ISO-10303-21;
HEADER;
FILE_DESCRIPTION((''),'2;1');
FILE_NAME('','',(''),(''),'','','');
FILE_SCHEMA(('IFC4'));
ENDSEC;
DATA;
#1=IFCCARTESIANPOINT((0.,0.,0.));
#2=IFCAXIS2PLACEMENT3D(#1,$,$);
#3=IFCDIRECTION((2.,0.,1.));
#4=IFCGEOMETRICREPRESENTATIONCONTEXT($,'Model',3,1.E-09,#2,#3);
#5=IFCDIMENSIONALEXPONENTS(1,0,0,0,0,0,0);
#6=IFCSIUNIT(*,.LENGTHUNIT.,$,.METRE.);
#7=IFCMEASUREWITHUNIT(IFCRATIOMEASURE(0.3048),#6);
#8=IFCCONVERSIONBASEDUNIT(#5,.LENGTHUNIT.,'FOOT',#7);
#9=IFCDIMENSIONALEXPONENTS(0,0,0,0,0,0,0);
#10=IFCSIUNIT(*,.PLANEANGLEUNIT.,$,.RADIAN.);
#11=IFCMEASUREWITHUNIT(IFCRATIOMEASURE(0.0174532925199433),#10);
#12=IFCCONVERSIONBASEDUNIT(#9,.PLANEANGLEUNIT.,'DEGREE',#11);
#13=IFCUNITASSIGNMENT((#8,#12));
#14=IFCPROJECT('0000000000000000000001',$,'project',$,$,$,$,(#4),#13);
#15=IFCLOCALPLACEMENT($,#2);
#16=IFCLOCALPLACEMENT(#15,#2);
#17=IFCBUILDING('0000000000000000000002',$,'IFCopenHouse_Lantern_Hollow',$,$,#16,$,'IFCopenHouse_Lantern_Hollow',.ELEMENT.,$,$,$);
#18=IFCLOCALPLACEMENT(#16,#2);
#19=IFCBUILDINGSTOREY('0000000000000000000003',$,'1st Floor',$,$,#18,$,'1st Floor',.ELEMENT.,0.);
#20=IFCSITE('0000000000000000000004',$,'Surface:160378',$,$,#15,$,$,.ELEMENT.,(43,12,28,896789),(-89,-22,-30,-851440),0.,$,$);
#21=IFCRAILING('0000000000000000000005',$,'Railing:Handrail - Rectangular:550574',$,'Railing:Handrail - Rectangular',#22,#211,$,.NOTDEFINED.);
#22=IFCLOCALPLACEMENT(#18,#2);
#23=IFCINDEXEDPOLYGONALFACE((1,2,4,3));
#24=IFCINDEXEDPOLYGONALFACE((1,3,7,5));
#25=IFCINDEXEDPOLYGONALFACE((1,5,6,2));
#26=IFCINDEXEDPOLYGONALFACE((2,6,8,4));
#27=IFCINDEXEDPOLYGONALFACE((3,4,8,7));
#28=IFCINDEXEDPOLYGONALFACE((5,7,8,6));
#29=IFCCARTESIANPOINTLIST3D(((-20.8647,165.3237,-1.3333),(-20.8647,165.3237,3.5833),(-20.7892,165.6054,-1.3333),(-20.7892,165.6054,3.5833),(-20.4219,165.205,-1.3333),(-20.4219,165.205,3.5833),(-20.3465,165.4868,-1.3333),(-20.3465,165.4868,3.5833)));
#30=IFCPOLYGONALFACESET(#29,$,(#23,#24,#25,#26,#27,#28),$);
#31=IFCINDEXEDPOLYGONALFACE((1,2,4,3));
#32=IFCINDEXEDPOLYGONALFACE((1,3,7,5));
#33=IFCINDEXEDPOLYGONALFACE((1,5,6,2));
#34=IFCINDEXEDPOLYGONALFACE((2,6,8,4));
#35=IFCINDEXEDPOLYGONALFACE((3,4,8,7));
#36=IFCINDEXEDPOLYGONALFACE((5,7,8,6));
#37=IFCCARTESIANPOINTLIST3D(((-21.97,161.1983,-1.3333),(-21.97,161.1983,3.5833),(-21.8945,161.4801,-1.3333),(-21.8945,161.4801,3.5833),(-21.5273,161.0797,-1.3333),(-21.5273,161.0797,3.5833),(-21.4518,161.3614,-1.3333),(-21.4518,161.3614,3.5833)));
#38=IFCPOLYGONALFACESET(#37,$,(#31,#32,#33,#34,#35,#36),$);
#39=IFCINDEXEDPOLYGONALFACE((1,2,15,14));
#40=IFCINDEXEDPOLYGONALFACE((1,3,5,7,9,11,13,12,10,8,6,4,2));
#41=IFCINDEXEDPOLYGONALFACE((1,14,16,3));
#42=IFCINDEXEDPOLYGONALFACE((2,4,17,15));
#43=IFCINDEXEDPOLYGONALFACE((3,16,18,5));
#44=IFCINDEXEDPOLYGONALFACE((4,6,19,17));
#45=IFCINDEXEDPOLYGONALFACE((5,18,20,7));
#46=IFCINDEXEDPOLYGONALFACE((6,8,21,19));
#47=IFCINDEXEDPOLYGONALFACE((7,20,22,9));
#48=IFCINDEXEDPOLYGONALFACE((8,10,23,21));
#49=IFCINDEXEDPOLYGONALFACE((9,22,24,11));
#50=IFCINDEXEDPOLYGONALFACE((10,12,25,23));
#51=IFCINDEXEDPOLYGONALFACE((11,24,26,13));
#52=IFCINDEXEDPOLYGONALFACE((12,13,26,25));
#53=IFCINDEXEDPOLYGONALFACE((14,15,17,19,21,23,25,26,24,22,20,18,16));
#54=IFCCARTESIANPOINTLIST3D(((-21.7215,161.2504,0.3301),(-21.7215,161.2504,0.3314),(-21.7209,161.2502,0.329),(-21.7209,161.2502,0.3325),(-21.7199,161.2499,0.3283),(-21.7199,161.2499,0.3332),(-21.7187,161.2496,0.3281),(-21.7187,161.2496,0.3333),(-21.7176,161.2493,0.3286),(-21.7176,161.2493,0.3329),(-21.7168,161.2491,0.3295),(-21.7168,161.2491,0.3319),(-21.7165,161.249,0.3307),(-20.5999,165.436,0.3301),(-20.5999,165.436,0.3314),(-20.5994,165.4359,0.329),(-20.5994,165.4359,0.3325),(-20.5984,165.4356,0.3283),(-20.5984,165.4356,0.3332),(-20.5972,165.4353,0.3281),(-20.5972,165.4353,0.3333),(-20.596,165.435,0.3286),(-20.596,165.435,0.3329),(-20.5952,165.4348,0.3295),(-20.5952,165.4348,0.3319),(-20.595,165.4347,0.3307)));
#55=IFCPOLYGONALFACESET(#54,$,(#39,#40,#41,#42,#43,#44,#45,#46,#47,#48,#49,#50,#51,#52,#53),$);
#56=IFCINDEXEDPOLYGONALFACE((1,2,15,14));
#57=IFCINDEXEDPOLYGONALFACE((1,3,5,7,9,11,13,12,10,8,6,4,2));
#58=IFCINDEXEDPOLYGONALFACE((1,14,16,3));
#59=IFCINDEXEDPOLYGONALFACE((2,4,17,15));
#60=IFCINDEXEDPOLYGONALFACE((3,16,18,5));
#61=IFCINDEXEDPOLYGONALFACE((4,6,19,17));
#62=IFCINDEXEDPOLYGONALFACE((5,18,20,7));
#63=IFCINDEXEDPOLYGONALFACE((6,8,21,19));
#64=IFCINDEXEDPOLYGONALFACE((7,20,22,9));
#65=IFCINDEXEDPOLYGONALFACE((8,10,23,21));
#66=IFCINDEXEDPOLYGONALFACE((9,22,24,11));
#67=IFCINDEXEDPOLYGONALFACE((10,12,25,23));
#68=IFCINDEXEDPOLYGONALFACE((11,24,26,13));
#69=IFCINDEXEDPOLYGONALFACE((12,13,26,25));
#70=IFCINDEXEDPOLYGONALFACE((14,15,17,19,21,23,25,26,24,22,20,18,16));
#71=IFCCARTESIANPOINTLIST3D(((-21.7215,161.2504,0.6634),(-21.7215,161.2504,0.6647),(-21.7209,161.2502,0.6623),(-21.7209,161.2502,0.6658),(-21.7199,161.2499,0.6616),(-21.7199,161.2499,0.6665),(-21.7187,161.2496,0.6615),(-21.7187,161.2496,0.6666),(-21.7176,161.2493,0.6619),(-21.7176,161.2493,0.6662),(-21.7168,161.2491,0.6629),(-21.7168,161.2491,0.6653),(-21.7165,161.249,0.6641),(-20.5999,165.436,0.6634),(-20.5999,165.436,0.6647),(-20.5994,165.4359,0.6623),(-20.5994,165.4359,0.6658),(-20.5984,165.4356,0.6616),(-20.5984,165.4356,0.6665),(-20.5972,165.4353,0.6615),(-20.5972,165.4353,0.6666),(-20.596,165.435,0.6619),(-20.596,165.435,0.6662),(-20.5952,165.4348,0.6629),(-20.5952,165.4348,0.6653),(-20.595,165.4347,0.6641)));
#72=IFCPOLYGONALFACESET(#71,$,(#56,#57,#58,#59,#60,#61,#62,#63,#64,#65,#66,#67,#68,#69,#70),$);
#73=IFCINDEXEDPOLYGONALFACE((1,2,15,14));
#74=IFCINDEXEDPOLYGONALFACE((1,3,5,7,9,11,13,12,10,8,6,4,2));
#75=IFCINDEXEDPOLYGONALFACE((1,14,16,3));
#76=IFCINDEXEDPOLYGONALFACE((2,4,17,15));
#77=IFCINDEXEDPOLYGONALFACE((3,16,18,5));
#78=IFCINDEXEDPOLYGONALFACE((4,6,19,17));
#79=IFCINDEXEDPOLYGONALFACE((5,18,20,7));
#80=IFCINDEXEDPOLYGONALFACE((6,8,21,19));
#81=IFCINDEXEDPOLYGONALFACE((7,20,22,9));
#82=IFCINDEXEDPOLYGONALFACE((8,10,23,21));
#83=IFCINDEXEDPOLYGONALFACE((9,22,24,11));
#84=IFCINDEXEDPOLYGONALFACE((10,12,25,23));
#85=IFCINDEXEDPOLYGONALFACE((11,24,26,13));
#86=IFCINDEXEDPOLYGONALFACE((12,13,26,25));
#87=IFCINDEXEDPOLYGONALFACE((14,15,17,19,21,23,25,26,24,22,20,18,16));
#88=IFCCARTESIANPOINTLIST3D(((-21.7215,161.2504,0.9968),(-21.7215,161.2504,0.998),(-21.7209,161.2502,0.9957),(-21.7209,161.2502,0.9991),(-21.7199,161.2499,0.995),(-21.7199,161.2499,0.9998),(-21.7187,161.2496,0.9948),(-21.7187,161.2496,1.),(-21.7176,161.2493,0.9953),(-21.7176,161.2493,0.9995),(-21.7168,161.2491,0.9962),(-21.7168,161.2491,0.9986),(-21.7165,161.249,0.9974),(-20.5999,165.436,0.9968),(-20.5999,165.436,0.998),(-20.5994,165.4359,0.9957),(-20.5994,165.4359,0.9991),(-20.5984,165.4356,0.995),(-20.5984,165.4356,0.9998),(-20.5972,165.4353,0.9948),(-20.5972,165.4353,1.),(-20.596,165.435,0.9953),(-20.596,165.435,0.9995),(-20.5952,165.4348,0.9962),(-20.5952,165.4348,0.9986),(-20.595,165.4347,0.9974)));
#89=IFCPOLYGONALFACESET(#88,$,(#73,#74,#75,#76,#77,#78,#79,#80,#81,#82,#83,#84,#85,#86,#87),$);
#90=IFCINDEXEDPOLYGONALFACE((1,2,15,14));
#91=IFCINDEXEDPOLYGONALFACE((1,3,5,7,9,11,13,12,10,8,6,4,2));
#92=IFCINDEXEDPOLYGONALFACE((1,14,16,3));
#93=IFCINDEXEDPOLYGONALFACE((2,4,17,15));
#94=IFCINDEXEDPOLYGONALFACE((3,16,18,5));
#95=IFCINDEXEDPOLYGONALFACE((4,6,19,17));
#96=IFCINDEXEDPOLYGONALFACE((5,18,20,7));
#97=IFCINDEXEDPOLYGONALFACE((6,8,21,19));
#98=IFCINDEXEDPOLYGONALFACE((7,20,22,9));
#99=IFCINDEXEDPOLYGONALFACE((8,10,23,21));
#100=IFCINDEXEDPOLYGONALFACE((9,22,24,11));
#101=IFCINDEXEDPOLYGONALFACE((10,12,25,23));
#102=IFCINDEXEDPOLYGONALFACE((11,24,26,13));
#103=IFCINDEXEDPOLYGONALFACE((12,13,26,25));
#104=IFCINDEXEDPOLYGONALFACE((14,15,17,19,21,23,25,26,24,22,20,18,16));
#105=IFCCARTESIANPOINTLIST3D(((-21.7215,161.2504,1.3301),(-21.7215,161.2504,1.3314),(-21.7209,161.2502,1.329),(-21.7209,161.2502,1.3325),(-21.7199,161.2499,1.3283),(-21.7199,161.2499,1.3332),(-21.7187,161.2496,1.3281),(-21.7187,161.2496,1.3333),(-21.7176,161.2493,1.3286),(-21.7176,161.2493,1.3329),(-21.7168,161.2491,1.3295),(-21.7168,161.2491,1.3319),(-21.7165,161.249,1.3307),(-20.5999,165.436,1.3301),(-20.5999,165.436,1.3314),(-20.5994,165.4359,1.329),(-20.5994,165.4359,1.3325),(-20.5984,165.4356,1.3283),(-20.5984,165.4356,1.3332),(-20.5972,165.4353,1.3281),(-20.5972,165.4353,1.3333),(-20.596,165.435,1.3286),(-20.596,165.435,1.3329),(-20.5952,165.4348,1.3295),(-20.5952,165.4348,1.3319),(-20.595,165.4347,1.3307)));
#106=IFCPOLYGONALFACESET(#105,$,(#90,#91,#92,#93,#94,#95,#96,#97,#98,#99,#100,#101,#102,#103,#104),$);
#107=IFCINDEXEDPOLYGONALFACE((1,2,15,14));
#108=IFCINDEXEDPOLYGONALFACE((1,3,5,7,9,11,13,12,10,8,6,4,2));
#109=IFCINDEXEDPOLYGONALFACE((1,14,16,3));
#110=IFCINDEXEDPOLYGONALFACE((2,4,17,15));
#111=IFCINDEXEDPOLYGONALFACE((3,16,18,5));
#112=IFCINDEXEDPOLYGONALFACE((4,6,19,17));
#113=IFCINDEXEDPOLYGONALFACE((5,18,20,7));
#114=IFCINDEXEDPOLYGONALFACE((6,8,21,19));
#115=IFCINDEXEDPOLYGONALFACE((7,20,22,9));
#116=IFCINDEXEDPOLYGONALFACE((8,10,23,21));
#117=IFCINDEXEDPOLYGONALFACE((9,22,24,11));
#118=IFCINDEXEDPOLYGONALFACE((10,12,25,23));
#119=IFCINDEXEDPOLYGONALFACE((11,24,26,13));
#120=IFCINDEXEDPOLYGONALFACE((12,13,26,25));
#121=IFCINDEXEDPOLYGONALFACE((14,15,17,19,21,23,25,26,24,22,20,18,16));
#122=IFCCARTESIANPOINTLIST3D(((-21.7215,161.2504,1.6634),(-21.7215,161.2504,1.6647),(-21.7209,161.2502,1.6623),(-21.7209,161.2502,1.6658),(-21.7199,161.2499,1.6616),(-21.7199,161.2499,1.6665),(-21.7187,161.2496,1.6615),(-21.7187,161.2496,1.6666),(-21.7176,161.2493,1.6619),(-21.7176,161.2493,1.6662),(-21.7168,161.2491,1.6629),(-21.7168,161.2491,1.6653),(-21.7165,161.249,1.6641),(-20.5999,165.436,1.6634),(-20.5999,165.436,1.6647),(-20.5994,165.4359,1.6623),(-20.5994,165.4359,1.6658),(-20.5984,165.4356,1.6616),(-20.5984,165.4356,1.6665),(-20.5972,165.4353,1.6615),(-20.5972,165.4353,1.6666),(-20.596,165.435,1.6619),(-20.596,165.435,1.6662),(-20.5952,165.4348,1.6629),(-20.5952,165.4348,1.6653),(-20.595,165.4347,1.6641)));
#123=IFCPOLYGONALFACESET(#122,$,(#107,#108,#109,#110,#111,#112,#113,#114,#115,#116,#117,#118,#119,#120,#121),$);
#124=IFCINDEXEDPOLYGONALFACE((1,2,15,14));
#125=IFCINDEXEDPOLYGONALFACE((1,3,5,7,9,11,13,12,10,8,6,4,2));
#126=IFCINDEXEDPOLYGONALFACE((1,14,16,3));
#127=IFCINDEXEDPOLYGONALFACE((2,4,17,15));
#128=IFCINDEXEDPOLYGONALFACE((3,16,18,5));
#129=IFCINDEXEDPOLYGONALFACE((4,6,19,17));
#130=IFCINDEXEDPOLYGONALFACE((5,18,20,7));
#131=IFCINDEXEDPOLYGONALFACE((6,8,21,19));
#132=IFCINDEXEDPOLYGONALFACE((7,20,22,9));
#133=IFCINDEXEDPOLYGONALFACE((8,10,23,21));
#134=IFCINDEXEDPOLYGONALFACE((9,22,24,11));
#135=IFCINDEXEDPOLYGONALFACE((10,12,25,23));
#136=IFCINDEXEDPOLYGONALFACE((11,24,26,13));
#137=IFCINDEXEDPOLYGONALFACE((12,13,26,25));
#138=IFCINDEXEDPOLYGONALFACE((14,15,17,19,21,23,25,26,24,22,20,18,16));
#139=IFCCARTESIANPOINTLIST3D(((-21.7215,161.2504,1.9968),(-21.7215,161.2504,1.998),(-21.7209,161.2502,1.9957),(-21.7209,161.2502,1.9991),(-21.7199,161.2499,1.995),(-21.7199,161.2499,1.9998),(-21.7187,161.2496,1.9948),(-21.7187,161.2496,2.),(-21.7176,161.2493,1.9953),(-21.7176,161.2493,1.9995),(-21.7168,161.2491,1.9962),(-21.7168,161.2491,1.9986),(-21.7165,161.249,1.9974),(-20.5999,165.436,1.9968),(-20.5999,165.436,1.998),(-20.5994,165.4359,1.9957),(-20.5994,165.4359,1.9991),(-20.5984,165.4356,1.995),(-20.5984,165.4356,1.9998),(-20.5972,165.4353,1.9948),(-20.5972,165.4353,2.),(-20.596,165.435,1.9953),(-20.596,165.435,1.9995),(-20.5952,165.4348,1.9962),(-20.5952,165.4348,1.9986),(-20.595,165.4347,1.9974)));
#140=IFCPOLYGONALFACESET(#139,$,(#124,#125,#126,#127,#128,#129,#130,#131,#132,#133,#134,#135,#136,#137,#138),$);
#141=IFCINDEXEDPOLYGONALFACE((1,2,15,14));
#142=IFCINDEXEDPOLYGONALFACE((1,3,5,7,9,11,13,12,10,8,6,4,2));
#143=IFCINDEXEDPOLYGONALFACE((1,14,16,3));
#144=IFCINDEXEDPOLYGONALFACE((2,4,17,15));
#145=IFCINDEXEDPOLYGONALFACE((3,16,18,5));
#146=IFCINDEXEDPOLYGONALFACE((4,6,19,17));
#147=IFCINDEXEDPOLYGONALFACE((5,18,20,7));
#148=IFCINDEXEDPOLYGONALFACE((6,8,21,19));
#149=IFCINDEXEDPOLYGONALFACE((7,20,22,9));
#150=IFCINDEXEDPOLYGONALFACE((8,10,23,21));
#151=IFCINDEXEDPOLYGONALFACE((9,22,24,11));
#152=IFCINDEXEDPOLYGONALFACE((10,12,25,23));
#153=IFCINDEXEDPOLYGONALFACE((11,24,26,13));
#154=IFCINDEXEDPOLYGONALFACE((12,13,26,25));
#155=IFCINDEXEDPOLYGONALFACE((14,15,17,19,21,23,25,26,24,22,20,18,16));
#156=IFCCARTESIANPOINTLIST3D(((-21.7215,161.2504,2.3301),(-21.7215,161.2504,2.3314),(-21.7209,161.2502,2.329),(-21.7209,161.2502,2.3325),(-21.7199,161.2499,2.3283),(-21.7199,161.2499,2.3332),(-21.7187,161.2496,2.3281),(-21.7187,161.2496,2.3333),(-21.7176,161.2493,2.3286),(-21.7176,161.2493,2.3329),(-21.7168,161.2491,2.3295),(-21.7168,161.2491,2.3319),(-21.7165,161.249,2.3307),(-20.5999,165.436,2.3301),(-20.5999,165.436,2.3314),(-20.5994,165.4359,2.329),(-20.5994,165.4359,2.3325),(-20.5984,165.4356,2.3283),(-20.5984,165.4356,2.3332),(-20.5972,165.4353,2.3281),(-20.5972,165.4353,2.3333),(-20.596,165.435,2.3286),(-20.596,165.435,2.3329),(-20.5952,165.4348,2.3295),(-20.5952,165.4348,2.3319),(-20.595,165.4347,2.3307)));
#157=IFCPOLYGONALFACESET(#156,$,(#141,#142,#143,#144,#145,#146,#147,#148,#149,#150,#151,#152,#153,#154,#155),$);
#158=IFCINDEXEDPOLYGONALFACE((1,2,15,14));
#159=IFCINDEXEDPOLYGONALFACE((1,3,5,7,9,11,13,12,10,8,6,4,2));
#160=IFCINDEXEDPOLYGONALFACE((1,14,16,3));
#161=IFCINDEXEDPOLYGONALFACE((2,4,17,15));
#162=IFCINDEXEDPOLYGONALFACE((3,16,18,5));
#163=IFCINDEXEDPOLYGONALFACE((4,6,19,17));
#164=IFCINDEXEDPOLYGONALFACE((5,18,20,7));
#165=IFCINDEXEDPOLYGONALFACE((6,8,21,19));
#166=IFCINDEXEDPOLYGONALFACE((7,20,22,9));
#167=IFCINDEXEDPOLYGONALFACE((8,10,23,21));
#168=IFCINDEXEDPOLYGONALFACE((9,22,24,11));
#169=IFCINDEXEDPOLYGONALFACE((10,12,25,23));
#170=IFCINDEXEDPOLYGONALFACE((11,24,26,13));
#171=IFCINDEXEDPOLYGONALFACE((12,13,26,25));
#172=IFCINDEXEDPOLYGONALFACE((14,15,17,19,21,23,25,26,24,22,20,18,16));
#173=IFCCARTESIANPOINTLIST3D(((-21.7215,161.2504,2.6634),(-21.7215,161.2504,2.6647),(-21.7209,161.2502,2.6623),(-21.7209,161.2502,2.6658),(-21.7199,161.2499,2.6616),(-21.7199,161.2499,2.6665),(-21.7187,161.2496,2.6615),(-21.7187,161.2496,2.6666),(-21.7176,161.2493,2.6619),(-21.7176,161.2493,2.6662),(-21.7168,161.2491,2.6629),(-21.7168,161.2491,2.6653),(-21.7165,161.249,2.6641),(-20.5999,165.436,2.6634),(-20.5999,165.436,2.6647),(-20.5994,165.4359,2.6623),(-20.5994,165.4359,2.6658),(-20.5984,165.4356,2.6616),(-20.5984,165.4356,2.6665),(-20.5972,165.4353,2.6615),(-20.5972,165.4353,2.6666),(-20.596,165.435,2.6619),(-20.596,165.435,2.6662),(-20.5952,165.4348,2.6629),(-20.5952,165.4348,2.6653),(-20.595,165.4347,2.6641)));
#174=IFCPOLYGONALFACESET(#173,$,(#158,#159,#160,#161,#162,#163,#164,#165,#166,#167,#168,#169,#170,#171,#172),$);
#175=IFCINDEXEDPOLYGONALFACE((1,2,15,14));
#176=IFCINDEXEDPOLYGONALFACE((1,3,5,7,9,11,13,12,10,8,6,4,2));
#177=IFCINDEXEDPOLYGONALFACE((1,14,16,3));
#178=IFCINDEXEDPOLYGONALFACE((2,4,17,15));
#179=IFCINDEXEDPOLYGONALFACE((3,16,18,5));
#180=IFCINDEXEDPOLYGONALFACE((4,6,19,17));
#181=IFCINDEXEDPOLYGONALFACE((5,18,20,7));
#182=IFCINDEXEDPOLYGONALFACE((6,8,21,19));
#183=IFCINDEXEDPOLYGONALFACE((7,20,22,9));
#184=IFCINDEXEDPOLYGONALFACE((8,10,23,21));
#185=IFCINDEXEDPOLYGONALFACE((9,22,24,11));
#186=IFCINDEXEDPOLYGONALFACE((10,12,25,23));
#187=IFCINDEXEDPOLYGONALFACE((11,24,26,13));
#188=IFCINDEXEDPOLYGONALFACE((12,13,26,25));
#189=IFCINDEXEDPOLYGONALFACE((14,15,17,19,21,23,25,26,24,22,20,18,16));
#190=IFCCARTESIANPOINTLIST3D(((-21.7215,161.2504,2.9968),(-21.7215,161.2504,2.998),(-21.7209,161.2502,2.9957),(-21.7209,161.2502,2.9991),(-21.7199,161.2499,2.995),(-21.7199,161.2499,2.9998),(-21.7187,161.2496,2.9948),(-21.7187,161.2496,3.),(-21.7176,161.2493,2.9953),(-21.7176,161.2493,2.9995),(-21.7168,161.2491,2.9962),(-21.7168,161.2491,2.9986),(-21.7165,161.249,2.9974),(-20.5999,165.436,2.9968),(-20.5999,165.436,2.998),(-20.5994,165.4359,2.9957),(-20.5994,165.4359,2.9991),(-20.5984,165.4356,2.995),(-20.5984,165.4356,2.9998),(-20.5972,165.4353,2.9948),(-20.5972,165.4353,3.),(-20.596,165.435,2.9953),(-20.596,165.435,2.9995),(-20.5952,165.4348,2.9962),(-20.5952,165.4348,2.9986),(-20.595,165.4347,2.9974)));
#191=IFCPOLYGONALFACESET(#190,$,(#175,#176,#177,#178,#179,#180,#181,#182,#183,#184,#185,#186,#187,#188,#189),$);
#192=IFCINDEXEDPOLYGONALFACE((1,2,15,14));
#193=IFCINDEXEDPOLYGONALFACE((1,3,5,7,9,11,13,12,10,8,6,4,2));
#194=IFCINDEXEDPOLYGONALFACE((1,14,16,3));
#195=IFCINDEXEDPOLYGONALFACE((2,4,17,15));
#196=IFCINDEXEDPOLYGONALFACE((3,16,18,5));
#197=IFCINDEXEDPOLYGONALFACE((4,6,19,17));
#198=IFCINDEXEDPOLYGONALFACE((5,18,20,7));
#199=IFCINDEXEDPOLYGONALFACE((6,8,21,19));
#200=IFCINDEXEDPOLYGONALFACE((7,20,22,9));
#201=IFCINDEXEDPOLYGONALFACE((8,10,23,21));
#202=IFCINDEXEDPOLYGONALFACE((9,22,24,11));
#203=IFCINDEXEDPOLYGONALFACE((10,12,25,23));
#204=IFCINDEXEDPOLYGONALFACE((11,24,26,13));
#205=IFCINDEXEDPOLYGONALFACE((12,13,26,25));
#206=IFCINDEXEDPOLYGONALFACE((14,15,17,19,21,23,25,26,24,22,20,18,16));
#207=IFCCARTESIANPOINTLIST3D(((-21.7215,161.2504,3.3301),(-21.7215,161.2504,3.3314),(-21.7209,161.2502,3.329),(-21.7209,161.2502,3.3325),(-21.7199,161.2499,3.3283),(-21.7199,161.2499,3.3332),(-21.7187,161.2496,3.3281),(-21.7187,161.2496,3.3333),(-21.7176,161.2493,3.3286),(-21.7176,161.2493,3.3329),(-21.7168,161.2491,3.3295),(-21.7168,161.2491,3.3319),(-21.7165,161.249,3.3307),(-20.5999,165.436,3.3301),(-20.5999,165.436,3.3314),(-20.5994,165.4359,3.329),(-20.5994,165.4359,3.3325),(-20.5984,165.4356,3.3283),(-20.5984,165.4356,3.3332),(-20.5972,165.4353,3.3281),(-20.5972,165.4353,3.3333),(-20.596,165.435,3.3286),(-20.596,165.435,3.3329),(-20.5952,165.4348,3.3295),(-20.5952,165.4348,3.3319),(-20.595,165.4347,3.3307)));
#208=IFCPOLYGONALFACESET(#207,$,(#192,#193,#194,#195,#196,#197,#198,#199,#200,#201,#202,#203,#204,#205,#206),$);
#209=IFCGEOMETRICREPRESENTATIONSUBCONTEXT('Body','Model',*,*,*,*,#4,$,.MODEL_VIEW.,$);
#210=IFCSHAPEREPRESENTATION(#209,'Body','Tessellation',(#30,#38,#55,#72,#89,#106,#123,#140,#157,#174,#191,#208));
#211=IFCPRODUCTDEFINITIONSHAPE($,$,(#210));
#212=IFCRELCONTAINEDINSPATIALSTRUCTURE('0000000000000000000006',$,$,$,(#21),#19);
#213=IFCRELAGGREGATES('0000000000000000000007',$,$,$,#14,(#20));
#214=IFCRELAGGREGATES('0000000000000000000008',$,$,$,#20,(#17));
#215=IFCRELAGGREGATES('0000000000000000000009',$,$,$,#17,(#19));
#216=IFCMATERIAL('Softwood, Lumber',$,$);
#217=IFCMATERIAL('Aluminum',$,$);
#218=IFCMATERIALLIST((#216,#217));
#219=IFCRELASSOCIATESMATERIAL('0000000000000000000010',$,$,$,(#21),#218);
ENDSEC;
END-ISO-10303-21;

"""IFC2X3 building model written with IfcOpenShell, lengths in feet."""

from ifc_helpers import new_model, entity, si_unit, converted_unit, direction, frame, frame_2d, origin, origin_2d_with_axis, place, context, subcontext, project, spatial, rectangle, circle, extrude, material, material_list, element, save


model = new_model("IFC2X3")

# Units and contexts
model_context = context("Model", 3, precision=1e-09, world=origin(), true_north=direction((2.0, 0.0, 1.0)))
body_context = subcontext(model_context, "Body", "Model", "MODEL_VIEW")
ifc_project = project(units=[converted_unit("LENGTHUNIT", "FOOT", entity("IfcRatioMeasure", 0.3048), si_unit("LENGTHUNIT", "METRE"), dimensions=[1, 0, 0, 0, 0, 0, 0]), converted_unit("PLANEANGLEUNIT", "DEGREE", entity("IfcRatioMeasure", 0.0174532925199433), si_unit("PLANEANGLEUNIT", "RADIAN"), dimensions=[0, 0, 0, 0, 0, 0, 0])], contexts=[model_context])

# Site, building, storey
site_placement = place(None, origin())
site = spatial("IfcSite", under=ifc_project, at=site_placement, Name="Surface:160378", CompositionType="ELEMENT", RefLatitude=(43, 12, 28, 896789), RefLongitude=(-89, -22, -30, -851440), RefElevation=0.0)
building_placement = place(site_placement, origin())
building = spatial("IfcBuilding", under=site, at=building_placement, Name="IFCopenHouse_Lantern_Hollow", LongName="IFCopenHouse_Lantern_Hollow", CompositionType="ELEMENT")
storey_placement = place(building_placement, origin())
storey = spatial("IfcBuildingStorey", under=building, at=storey_placement, Name="1st Floor", LongName="1st Floor", CompositionType="ELEMENT", Elevation=0.0)

# Shared definitions
ifc_material_1 = material(Name="Softwood, Lumber")

# Railing
ifc_material_2 = material(Name="Aluminum")
ifc_material_list_1 = material_list([ifc_material_1, ifc_material_2])
railing_placement = place(storey_placement, frame((-21.97, 161.0797, -1.3333)))
element("IfcRailing", 1, at=railing_placement, inside=storey, material=ifc_material_list_1, Name="Railing:Handrail - Rectangular:550574", ObjectType="Railing:Handrail - Rectangular", PredefinedType="NOTDEFINED", context=body_context, shape_type="SweptSolid", body=[
    extrude(rectangle(XDim=0.2917, YDim=0.4583, at=origin_2d_with_axis()), frame((1.3645, 4.3255, 0.0), z_axis=(0.0, 0.0, 1.0), x_axis=(0.258819, 0.965926, 0.0)), (0.0, 0.0, 1.0), 4.9167),
    extrude(rectangle(XDim=0.2917, YDim=0.4583, at=origin_2d_with_axis()), frame((0.2591, 0.2002, 0.0), z_axis=(0.0, 0.0, 1.0), x_axis=(0.258819, 0.965926, 0.0)), (0.0, 0.0, 1.0), 4.9167),
    extrude(circle(Radius=0.0026, at=frame_2d((0.0, 0.0), x_axis=(1.0, 0.0))), frame((0.251, 0.17, 1.6641), z_axis=(0.258819, 0.965926, 0.0), x_axis=(0.965926, -0.258819, 0.0)), (0.0, 0.0, 1.0), 4.3333),
    extrude(circle(Radius=0.0026, at=frame_2d((0.0, 0.0), x_axis=(1.0, 0.0))), frame((0.251, 0.17, 1.9974), z_axis=(0.258819, 0.965926, 0.0), x_axis=(0.965926, -0.258819, 0.0)), (0.0, 0.0, 1.0), 4.3333),
    extrude(circle(Radius=0.0026, at=frame_2d((0.0, 0.0), x_axis=(1.0, 0.0))), frame((0.251, 0.17, 2.3307), z_axis=(0.258819, 0.965926, 0.0), x_axis=(0.965926, -0.258819, 0.0)), (0.0, 0.0, 1.0), 4.3333),
    extrude(circle(Radius=0.0026, at=frame_2d((0.0, 0.0), x_axis=(1.0, 0.0))), frame((0.251, 0.17, 2.6641), z_axis=(0.258819, 0.965926, 0.0), x_axis=(0.965926, -0.258819, 0.0)), (0.0, 0.0, 1.0), 4.3333),
    extrude(circle(Radius=0.0026, at=frame_2d((0.0, 0.0), x_axis=(1.0, 0.0))), frame((0.251, 0.17, 2.9974), z_axis=(0.258819, 0.965926, 0.0), x_axis=(0.965926, -0.258819, 0.0)), (0.0, 0.0, 1.0), 4.3333),
    extrude(circle(Radius=0.0026, at=frame_2d((0.0, 0.0), x_axis=(1.0, 0.0))), frame((0.251, 0.17, 3.3307), z_axis=(0.258819, 0.965926, 0.0), x_axis=(0.965926, -0.258819, 0.0)), (0.0, 0.0, 1.0), 4.3333),
    extrude(circle(Radius=0.0026, at=frame_2d((0.0, 0.0), x_axis=(1.0, 0.0))), frame((0.251, 0.17, 3.6641), z_axis=(0.258819, 0.965926, 0.0), x_axis=(0.965926, -0.258819, 0.0)), (0.0, 0.0, 1.0), 4.3333),
    extrude(circle(Radius=0.0026, at=frame_2d((0.0, 0.0), x_axis=(1.0, 0.0))), frame((0.251, 0.17, 3.9974), z_axis=(0.258819, 0.965926, 0.0), x_axis=(0.965926, -0.258819, 0.0)), (0.0, 0.0, 1.0), 4.3333),
    extrude(circle(Radius=0.0026, at=frame_2d((0.0, 0.0), x_axis=(1.0, 0.0))), frame((0.251, 0.17, 4.3307), z_axis=(0.258819, 0.965926, 0.0), x_axis=(0.965926, -0.258819, 0.0)), (0.0, 0.0, 1.0), 4.3333),
    extrude(circle(Radius=0.0026, at=frame_2d((0.0, 0.0), x_axis=(1.0, 0.0))), frame((0.251, 0.17, 4.6641), z_axis=(0.258819, 0.965926, 0.0), x_axis=(0.965926, -0.258819, 0.0)), (0.0, 0.0, 1.0), 4.3333),
])

save(model, "model.ifc")
